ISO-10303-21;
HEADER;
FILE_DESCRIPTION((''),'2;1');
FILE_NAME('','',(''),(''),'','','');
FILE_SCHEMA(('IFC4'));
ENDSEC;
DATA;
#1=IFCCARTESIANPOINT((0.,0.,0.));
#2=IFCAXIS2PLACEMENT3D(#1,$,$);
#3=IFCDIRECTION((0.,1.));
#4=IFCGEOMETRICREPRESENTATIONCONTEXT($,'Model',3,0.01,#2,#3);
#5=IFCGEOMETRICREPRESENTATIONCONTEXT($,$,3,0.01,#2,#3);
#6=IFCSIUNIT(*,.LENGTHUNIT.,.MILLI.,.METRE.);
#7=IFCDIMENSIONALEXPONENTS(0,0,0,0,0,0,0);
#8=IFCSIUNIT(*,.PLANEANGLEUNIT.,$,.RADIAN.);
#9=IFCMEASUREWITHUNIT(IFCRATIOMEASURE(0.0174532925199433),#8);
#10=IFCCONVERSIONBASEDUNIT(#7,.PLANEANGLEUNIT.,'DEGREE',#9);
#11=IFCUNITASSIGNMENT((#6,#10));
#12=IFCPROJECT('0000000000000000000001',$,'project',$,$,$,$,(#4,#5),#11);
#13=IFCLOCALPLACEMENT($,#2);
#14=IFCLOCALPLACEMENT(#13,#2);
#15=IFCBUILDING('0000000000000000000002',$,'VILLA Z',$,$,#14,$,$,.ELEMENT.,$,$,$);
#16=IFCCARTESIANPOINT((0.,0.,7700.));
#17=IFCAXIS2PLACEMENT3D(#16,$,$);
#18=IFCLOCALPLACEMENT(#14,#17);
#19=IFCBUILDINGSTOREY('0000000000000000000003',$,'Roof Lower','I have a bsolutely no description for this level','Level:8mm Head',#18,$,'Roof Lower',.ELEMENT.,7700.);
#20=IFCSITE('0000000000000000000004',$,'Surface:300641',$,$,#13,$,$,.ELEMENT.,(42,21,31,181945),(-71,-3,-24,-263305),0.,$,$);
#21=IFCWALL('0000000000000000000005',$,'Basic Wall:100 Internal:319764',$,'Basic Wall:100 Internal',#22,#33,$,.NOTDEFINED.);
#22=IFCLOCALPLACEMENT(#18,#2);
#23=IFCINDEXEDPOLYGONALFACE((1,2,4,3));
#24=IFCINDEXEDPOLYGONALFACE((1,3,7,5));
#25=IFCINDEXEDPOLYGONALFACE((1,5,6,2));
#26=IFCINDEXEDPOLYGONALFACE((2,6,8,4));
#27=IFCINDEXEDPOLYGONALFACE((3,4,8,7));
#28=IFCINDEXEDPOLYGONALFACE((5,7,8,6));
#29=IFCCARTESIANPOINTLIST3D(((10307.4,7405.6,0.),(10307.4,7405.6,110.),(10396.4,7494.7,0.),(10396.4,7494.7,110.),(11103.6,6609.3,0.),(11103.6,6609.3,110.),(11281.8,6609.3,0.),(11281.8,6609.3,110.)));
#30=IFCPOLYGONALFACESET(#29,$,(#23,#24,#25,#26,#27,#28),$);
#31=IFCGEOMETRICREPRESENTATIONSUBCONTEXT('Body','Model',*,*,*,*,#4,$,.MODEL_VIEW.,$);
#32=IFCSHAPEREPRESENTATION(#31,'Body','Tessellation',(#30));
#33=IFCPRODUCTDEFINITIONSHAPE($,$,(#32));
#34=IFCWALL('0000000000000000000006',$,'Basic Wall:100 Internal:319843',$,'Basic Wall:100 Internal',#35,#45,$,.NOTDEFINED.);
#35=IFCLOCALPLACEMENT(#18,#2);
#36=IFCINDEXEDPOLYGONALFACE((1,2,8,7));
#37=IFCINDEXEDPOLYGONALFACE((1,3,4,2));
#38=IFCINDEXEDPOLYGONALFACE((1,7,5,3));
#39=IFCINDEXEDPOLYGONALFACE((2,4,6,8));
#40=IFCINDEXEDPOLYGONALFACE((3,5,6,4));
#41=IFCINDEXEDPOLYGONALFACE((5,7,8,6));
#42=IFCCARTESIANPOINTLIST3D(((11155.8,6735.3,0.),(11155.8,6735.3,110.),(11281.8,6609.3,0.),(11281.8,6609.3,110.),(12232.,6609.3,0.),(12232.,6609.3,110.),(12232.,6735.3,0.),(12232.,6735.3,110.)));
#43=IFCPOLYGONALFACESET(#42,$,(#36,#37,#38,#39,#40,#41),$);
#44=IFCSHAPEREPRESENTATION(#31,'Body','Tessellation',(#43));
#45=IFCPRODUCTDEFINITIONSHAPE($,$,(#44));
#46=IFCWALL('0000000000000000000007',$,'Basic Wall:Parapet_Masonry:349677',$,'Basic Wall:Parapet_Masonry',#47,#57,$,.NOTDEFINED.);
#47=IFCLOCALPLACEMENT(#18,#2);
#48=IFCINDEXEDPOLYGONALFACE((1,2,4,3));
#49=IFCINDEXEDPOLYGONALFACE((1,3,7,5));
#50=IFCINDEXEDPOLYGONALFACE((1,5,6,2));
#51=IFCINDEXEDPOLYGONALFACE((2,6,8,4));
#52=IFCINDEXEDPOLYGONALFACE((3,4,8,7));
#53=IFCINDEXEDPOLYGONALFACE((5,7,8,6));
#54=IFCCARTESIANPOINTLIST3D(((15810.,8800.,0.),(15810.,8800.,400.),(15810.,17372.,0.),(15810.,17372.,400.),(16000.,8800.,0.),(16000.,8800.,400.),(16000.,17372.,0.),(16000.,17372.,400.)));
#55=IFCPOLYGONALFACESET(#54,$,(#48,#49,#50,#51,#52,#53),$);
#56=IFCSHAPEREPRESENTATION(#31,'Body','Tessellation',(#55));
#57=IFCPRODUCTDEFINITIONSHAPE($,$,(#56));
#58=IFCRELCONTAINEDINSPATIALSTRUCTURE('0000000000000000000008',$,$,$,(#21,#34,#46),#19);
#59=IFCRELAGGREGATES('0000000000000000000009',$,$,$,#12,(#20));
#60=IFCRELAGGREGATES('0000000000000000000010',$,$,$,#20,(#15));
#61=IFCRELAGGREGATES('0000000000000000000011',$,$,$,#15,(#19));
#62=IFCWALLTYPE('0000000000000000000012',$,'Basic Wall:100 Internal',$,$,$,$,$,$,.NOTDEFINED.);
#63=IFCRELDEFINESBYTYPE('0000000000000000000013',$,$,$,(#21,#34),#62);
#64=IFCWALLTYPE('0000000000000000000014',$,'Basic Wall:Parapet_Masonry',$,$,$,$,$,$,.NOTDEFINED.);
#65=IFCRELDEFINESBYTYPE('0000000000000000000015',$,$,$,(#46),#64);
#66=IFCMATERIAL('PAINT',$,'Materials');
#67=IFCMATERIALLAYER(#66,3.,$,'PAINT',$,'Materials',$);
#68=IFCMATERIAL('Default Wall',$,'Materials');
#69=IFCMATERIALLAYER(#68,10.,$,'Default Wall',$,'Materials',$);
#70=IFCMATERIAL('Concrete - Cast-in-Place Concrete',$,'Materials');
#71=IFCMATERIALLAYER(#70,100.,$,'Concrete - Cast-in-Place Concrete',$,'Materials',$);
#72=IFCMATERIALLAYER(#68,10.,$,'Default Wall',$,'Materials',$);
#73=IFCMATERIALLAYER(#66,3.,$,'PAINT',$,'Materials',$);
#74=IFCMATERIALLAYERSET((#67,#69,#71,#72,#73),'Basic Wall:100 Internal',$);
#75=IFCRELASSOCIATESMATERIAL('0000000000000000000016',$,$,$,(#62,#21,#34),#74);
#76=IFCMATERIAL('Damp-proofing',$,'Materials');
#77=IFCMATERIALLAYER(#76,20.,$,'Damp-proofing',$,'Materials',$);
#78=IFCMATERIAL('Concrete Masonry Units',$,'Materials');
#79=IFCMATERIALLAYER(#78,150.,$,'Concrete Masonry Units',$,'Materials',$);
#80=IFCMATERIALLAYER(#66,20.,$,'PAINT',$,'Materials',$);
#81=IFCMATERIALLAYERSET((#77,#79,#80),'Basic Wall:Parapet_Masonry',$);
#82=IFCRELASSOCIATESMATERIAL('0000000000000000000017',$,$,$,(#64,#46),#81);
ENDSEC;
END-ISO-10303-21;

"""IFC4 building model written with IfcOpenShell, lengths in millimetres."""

from ifc_helpers import new_model, entity, si_unit, converted_unit, direction, frame, frame_2d, origin, place, context, subcontext, project, spatial, polyline, rectangle, outline, extrude, clip, halfspace, bounded_halfspace, material, layer, layer_set, layer_usage, type_object, element, save


model = new_model("IFC4")

# Units and contexts
model_context = context("Model", 3, precision=0.01, world=origin(), true_north=direction((0.0, 1.0)))
context_of_model = context(None, 3, precision=0.01, world=origin(), true_north=direction((0.0, 1.0)))
body_context = subcontext(model_context, "Body", "Model", "MODEL_VIEW")
ifc_project = project(units=[si_unit("LENGTHUNIT", "METRE", prefix="MILLI"), converted_unit("PLANEANGLEUNIT", "DEGREE", entity("IfcRatioMeasure", 0.0174532925199433), si_unit("PLANEANGLEUNIT", "RADIAN"), dimensions=[0, 0, 0, 0, 0, 0, 0])], contexts=[model_context, context_of_model])

# Site, building, storey
site_placement = place(None, origin())
site = spatial("IfcSite", under=ifc_project, at=site_placement, Name="Surface:300641", CompositionType="ELEMENT", RefLatitude=(42, 21, 31, 181945), RefLongitude=(-71, -3, -24, -263305), RefElevation=0.0)
building_placement = place(site_placement, origin())
building = spatial("IfcBuilding", under=site, at=building_placement, Name="VILLA Z", CompositionType="ELEMENT")
storey_placement = place(building_placement, frame((0.0, 0.0, 7700.0)))
storey = spatial("IfcBuildingStorey", under=building, at=storey_placement, Name="Roof Lower", Description="I have a bsolutely no description for this level", ObjectType="Level:8mm Head", LongName="Roof Lower", CompositionType="ELEMENT", Elevation=7700.0)

# Shared definitions
ifc_material_1 = material(Name="Concrete - Cast-in-Place Concrete", Category="Materials")

# Shared definitions
ifc_material_2 = material(Name="Damp-proofing", Category="Materials")

# Walls
ifc_material_3 = material(Name="PAINT", Category="Materials")
ifc_material_4 = material(Name="Default Wall", Category="Materials")
ifc_layer_1 = layer(ifc_material_3, 3.0, Name="PAINT", Category="Materials")
ifc_layer_2 = layer(ifc_material_4, 10.0, Name="Default Wall", Category="Materials")
ifc_layer_3 = layer(ifc_material_1, 100.0, Name="Concrete - Cast-in-Place Concrete", Category="Materials")
ifc_layer_4 = layer(ifc_material_4, 10.0, Name="Default Wall", Category="Materials")
ifc_layer_5 = layer(ifc_material_3, 3.0, Name="PAINT", Category="Materials")
ifc_layer_set_1 = layer_set([ifc_layer_1, ifc_layer_2, ifc_layer_3, ifc_layer_4, ifc_layer_5], Name="Basic Wall:100 Internal")
wall_type_1 = type_object("IfcWallType", Name="Basic Wall:100 Internal", PredefinedType="NOTDEFINED", material=ifc_layer_set_1)
ifc_layer_usage_1 = layer_usage(ifc_layer_set_1, "AXIS2", "NEGATIVE", 63.0)
wall_1_placement = place(storey_placement, frame((10351.9, 7450.1, 0.0), z_axis=(0.0, 0.0, 1.0), x_axis=(0.707107, -0.707107, 0.0)))
element("IfcWall", 1, at=wall_1_placement, inside=storey, type_object=wall_type_1, material=ifc_layer_usage_1, Name="Basic Wall:100 Internal:319764", ObjectType="Basic Wall:100 Internal", PredefinedType="NOTDEFINED", context=body_context, shape_type="Clipping", body=[
    clip(clip(extrude(outline(polyline([(1126.1, -63.0), (1252.1, 63.0), (1073.9, 63.0), (0.0, 63.0), (0.0, -63.0), (1126.1, -63.0)])), origin(), (0.0, 0.0, 1.0), 110.0), bounded_halfspace(frame((0.0, -63.0, 110.0), z_axis=(0.0, 0.0, -1.0), x_axis=(0.707107, 0.707107, 0.0)), True, frame((0.0, -63.0, 110.0)), polyline([(0.0, 0.0), (1126.1, 0.0), (1252.1, 126.0), (1073.9, 126.0), (0.0, 126.0), (0.0, 0.0)]))), halfspace(frame((0.0, 0.0, -3500.0)), True)),
])
ifc_layer_usage_2 = layer_usage(ifc_layer_set_1, "AXIS2", "NEGATIVE", 63.0)
wall_2_placement = place(storey_placement, frame((11155.8, 6672.3, 0.0)))
element("IfcWall", 2, at=wall_2_placement, inside=storey, type_object=wall_type_1, material=ifc_layer_usage_2, Name="Basic Wall:100 Internal:319843", ObjectType="Basic Wall:100 Internal", PredefinedType="NOTDEFINED", context=body_context, shape_type="Clipping", body=[
    clip(clip(extrude(outline(polyline([(126.0, -63.0), (1076.2, -63.0), (1076.2, 63.0), (0.0, 63.0), (126.0, -63.0)])), origin(), (0.0, 0.0, 1.0), 110.0), bounded_halfspace(frame((126.0, -63.0, 110.0), z_axis=(0.0, 0.0, -1.0), x_axis=(1.0, 0.0, 0.0)), True, frame((126.0, -63.0, 110.0)), polyline([(0.0, 0.0), (950.2, 0.0), (950.2, 126.0), (-126.0, 126.0), (0.0, 0.0)]))), halfspace(frame((0.0, 0.0, -3500.0)), True)),
])
ifc_layer_6 = layer(ifc_material_2, 20.0, Name="Damp-proofing", Category="Materials")
ifc_material_5 = material(Name="Concrete Masonry Units", Category="Materials")
ifc_layer_7 = layer(ifc_material_5, 150.0, Name="Concrete Masonry Units", Category="Materials")
ifc_layer_8 = layer(ifc_material_3, 20.0, Name="PAINT", Category="Materials")
ifc_layer_set_2 = layer_set([ifc_layer_6, ifc_layer_7, ifc_layer_8], Name="Basic Wall:Parapet_Masonry")
ifc_layer_usage_3 = layer_usage(ifc_layer_set_2, "AXIS2", "NEGATIVE", 95.0)
wall_type_2 = type_object("IfcWallType", Name="Basic Wall:Parapet_Masonry", PredefinedType="NOTDEFINED", material=ifc_layer_set_2)
wall_3_placement = place(storey_placement, frame((15905.0, 8800.0, 0.0), z_axis=(0.0, 0.0, 1.0), x_axis=(0.0, 1.0, 0.0)))
element("IfcWall", 3, at=wall_3_placement, inside=storey, type_object=wall_type_2, material=ifc_layer_usage_3, Name="Basic Wall:Parapet_Masonry:349677", ObjectType="Basic Wall:Parapet_Masonry", PredefinedType="NOTDEFINED", context=body_context, shape_type="Clipping", body=[
    clip(extrude(rectangle(XDim=8572.0, YDim=190.0, at=frame_2d((4286.0, 0.0), x_axis=(-1.0, 0.0))), origin(), (0.0, 0.0, 1.0), 400.0), halfspace(origin(), True)),
])

save(model, "model.ifc")
